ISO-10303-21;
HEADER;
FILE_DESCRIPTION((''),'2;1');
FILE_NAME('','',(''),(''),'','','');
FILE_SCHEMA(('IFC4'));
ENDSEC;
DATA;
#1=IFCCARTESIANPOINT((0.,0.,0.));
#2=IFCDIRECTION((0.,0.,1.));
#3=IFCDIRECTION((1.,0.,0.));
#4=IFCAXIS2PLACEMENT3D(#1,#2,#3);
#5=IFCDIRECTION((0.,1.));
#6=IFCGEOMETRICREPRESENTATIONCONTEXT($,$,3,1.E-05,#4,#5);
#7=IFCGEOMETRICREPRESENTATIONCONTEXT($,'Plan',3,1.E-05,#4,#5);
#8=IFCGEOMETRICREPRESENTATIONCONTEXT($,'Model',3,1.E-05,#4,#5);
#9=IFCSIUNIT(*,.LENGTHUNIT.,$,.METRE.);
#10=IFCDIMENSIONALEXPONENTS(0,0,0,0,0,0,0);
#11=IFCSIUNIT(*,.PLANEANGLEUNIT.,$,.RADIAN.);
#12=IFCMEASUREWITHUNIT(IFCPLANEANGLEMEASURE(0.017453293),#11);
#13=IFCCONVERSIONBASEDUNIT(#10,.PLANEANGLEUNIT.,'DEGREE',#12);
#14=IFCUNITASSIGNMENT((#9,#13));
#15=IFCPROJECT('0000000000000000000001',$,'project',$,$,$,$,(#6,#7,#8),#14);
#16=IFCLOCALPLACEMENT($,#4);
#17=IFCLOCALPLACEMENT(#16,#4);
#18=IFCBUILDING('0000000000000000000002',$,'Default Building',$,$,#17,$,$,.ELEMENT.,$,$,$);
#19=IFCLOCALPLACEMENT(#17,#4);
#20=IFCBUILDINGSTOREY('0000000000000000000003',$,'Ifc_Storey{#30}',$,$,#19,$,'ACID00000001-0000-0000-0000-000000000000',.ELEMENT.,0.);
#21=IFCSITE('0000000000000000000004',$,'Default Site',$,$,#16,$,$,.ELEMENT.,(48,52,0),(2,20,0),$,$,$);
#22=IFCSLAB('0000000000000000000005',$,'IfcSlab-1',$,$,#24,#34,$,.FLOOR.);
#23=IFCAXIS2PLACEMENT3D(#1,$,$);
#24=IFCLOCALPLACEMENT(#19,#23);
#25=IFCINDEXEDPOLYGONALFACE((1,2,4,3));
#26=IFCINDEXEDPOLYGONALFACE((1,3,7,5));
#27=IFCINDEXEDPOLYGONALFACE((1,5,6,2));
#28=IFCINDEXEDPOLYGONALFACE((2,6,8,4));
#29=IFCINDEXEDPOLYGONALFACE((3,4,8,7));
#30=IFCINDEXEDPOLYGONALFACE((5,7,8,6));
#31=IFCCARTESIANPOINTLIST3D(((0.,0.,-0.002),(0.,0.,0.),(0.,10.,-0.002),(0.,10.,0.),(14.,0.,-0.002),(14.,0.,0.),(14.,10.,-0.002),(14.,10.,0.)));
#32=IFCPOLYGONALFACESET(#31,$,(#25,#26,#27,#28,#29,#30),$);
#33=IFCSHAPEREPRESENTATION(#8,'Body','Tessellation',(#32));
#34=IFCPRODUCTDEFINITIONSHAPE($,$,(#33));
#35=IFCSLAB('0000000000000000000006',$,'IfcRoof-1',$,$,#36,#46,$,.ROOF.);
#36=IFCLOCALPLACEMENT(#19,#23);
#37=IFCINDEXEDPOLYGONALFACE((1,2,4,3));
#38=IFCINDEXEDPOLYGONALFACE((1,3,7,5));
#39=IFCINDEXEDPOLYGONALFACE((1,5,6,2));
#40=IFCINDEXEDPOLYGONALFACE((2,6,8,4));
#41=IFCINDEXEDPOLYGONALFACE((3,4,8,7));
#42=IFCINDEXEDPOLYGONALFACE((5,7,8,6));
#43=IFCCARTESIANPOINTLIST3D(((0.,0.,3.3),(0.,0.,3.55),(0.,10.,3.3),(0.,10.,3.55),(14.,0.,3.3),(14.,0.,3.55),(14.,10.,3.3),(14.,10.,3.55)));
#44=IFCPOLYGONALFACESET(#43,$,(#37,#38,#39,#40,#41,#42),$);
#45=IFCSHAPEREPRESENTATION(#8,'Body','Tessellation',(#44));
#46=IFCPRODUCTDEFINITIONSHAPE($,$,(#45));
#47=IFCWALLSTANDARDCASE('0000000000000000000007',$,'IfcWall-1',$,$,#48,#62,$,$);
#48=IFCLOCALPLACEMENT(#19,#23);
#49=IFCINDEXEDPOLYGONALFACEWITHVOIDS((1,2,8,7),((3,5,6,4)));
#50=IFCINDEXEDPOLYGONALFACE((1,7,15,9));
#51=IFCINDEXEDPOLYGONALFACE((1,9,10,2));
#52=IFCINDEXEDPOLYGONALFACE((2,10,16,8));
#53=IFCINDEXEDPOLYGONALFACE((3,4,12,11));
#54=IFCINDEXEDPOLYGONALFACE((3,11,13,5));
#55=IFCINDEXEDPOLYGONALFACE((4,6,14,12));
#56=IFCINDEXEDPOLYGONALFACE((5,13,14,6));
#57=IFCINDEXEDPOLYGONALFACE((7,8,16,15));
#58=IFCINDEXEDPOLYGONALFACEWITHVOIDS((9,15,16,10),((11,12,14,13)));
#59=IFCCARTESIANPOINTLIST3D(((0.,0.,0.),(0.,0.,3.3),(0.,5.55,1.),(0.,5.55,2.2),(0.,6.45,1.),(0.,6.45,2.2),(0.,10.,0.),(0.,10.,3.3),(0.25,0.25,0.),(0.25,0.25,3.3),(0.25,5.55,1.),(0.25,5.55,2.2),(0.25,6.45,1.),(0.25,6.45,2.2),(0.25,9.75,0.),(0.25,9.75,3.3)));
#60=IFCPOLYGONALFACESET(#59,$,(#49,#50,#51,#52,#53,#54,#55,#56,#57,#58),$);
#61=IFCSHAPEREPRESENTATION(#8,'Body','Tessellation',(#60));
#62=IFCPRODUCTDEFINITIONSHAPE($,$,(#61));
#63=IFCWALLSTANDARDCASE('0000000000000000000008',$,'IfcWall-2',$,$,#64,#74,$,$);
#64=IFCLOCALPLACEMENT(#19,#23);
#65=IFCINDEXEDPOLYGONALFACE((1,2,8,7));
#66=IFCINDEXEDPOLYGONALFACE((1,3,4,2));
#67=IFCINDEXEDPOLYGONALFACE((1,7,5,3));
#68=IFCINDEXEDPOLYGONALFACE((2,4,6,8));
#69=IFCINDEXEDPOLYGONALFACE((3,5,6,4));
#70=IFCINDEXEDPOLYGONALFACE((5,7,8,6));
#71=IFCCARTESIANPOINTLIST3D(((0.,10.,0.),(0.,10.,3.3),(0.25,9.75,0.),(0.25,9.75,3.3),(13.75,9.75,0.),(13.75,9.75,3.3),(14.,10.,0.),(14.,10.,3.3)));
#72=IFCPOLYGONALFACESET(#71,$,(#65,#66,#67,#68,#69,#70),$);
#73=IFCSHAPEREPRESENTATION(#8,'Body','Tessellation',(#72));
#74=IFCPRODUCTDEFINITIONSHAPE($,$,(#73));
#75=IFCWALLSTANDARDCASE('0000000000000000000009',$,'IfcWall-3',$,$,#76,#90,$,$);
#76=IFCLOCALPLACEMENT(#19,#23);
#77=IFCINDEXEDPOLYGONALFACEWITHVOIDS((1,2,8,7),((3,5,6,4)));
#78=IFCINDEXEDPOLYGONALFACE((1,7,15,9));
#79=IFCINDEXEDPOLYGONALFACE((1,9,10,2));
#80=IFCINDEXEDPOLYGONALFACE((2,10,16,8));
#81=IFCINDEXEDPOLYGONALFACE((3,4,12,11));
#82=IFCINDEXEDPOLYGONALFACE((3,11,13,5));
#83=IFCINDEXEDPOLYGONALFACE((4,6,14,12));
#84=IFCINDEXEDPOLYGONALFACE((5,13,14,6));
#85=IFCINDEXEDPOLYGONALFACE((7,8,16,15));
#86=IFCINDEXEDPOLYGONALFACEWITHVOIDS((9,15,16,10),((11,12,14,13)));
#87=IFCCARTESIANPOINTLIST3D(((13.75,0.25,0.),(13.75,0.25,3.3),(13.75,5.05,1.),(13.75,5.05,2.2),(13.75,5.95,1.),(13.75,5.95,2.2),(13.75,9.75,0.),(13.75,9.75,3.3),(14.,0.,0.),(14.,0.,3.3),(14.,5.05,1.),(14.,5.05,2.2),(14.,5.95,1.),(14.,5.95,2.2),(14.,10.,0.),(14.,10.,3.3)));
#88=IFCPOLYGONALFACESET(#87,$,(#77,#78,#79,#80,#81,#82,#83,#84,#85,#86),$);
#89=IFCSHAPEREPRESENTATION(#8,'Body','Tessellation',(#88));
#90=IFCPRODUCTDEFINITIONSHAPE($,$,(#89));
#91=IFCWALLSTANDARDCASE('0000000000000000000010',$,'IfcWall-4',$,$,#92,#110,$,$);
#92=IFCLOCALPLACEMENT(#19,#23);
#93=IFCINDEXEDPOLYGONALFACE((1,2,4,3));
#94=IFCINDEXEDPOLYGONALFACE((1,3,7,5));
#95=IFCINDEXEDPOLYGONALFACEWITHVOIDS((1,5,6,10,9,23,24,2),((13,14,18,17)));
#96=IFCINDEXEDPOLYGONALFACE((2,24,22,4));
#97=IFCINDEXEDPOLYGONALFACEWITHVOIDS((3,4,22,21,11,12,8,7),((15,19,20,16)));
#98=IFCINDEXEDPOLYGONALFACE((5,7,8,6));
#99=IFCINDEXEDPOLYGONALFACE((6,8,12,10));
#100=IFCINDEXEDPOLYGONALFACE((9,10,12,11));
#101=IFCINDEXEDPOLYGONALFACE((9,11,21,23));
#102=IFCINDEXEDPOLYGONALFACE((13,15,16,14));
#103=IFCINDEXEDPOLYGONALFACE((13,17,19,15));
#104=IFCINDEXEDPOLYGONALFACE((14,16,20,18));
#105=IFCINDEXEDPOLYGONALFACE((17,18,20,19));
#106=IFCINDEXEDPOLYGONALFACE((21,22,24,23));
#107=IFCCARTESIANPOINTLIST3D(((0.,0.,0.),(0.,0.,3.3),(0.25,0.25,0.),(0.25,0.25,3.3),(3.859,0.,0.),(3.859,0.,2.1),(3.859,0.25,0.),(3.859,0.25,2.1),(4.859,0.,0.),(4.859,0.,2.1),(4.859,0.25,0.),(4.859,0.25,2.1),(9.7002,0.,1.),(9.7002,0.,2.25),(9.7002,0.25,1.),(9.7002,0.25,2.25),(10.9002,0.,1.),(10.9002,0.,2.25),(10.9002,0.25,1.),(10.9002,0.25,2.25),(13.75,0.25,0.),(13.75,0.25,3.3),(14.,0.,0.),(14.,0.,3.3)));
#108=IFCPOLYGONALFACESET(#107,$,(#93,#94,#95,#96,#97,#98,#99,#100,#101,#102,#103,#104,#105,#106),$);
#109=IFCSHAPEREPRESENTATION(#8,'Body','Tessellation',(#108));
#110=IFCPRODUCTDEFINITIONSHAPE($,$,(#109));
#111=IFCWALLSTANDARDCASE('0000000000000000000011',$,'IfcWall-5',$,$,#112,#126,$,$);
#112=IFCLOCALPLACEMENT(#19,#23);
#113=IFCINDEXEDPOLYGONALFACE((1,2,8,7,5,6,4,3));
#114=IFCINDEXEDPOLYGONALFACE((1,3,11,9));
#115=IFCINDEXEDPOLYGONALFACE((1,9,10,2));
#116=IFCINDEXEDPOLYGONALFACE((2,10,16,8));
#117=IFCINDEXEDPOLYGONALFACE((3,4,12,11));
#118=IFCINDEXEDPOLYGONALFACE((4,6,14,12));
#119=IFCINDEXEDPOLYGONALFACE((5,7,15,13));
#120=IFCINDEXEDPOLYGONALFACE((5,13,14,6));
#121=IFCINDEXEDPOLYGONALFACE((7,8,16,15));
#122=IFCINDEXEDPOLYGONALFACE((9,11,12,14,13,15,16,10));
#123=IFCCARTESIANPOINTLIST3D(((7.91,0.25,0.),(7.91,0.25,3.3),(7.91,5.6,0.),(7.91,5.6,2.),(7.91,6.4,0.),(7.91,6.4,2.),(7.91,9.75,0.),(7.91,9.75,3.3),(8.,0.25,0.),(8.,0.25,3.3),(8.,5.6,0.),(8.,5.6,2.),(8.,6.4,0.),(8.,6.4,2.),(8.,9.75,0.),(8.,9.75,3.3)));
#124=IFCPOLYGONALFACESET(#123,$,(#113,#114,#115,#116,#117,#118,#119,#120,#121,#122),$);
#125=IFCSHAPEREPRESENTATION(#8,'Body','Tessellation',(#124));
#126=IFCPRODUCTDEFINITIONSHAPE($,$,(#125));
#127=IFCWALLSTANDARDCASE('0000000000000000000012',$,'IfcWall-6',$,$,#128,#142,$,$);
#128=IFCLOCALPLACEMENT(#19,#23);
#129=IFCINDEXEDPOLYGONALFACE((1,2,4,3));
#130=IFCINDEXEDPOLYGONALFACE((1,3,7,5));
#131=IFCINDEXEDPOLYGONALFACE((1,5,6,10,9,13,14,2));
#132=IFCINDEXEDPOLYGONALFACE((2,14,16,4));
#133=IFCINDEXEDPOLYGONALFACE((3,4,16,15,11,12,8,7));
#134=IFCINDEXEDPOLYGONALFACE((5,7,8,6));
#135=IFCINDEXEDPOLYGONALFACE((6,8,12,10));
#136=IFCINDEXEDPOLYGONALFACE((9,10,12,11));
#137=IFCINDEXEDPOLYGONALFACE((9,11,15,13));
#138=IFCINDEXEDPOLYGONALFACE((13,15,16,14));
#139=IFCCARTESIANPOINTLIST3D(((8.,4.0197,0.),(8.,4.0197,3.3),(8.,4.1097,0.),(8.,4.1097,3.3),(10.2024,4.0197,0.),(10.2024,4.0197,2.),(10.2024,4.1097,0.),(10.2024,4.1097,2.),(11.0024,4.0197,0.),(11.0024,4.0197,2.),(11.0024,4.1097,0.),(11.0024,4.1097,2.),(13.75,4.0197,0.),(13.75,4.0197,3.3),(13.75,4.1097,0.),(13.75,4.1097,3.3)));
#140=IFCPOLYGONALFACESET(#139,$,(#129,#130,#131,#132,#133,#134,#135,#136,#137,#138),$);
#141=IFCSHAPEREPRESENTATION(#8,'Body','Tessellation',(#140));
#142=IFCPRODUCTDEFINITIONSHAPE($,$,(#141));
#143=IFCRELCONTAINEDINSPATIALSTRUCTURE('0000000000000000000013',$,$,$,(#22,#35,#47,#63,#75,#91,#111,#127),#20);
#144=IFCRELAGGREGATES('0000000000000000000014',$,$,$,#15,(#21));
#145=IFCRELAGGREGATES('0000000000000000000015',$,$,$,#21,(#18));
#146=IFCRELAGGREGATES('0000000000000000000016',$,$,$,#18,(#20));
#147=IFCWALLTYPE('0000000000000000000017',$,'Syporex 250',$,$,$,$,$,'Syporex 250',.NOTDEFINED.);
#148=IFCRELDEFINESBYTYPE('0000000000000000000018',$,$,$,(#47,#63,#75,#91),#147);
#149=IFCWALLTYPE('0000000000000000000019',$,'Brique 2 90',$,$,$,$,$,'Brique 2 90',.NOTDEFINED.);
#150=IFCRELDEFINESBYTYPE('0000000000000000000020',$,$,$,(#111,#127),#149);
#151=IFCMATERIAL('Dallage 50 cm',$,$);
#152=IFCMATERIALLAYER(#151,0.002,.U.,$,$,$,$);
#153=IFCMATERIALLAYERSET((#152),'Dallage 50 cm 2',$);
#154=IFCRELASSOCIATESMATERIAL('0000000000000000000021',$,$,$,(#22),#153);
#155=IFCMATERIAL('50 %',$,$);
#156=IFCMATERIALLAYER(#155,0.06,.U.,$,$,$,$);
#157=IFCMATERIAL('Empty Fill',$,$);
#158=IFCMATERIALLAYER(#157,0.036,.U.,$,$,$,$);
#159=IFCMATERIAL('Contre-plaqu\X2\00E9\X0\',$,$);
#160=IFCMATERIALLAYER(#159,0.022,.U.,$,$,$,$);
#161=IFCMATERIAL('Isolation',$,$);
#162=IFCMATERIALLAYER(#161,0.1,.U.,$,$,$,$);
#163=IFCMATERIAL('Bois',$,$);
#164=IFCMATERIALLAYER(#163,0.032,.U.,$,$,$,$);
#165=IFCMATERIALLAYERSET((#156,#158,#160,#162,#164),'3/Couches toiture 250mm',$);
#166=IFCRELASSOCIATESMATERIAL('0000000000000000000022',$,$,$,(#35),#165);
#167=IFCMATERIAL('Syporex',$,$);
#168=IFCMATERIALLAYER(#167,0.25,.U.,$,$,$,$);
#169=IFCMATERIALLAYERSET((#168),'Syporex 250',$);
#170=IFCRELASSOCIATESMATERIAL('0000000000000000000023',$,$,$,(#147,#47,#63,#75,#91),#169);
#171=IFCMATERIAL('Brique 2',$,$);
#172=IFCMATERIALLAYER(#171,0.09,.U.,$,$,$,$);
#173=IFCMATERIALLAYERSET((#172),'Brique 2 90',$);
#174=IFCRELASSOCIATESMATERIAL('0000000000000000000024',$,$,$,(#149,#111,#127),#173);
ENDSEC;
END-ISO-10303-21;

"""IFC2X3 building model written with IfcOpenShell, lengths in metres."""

from ifc_helpers import new_model, entity, si_unit, converted_unit, direction, frame, frame_2d, origin_with_axes, place, context, project, spatial, polyline, rectangle, outline, extrude, material, layer, layer_set, layer_usage, type_object, element, save


model = new_model("IFC2X3")

# Units and contexts
context_of_model = context(None, 3, precision=1e-05, world=origin_with_axes(), true_north=direction((0.0, 1.0)))
plan_context = context("Plan", 3, precision=1e-05, world=origin_with_axes(), true_north=direction((0.0, 1.0)))
model_context = context("Model", 3, precision=1e-05, world=origin_with_axes(), true_north=direction((0.0, 1.0)))
ifc_project = project(units=[si_unit("LENGTHUNIT", "METRE"), converted_unit("PLANEANGLEUNIT", "DEGREE", entity("IfcPlaneAngleMeasure", 0.017453293), si_unit("PLANEANGLEUNIT", "RADIAN"), dimensions=[0, 0, 0, 0, 0, 0, 0])], contexts=[context_of_model, plan_context, model_context])

# Site, building, storey
site_placement = place(None, origin_with_axes())
site = spatial("IfcSite", under=ifc_project, at=site_placement, Name="Default Site", CompositionType="ELEMENT", RefLatitude=(48, 52, 0), RefLongitude=(2, 20, 0))
building_placement = place(site_placement, origin_with_axes())
building = spatial("IfcBuilding", under=site, at=building_placement, Name="Default Building", CompositionType="ELEMENT")
storey_placement = place(building_placement, origin_with_axes())
storey = spatial("IfcBuildingStorey", under=building, at=storey_placement, Name="Ifc_Storey{#30}", LongName="ACID00000001-0000-0000-0000-000000000000", CompositionType="ELEMENT", Elevation=0.0)

# Slabs
ifc_material_1 = material(Name="Dallage 50 cm")
ifc_layer_1 = layer(ifc_material_1, 0.002, ventilated="UNKNOWN")
ifc_layer_set_1 = layer_set([ifc_layer_1], Name="Dallage 50 cm 2")
ifc_layer_usage_1 = layer_usage(ifc_layer_set_1, "AXIS3", "NEGATIVE", 0.002)
slab_1_placement = place(storey_placement, frame((0.0, 10.0, -0.002), z_axis=(0.0, 0.0, 1.0), x_axis=(0.0, -1.0, 0.0)))
element("IfcSlab", 1, at=slab_1_placement, inside=storey, material=ifc_layer_usage_1, Name="IfcSlab-1", PredefinedType="FLOOR", context=model_context, shape_type="SweptSolid", body=[
    extrude(outline(polyline([(0.0, 0.0), (10.0, 0.0), (10.0, 14.0), (0.0, 14.0), (0.0, 0.0)])), origin_with_axes(), (0.0, 0.0, 1.0), 0.002),
])
ifc_material_2 = material(Name="50 %")
ifc_layer_2 = layer(ifc_material_2, 0.06, ventilated="UNKNOWN")
ifc_material_3 = material(Name="Empty Fill")
ifc_layer_3 = layer(ifc_material_3, 0.036, ventilated="UNKNOWN")
ifc_material_4 = material(Name="Contre-plaqué")
ifc_layer_4 = layer(ifc_material_4, 0.022, ventilated="UNKNOWN")
ifc_material_5 = material(Name="Isolation")
ifc_layer_5 = layer(ifc_material_5, 0.1, ventilated="UNKNOWN")
ifc_material_6 = material(Name="Bois")
ifc_layer_6 = layer(ifc_material_6, 0.032, ventilated="UNKNOWN")
ifc_layer_set_2 = layer_set([ifc_layer_2, ifc_layer_3, ifc_layer_4, ifc_layer_5, ifc_layer_6], Name="3/Couches toiture 250mm")
ifc_layer_usage_2 = layer_usage(ifc_layer_set_2, "AXIS3", "NEGATIVE", 0.25)
slab_2_placement = place(storey_placement, frame((0.0, 10.0, 3.3), z_axis=(0.0, 0.0, 1.0), x_axis=(1.0, 0.0, 0.0)))
element("IfcSlab", 2, at=slab_2_placement, inside=storey, material=ifc_layer_usage_2, Name="IfcRoof-1", PredefinedType="ROOF", context=model_context, shape_type="SweptSolid", body=[
    extrude(outline(polyline([(0.0, 0.0), (0.0, -10.0), (14.0, -10.0), (14.0, 0.0), (0.0, 0.0)])), origin_with_axes(), (0.0, 0.0, 1.0), 0.25),
])

# Wall, opening
ifc_material_7 = material(Name="Syporex")
ifc_layer_7 = layer(ifc_material_7, 0.25, ventilated="UNKNOWN")
ifc_layer_set_3 = layer_set([ifc_layer_7], Name="Syporex 250")
ifc_layer_usage_3 = layer_usage(ifc_layer_set_3, "AXIS2", "NEGATIVE", 0.0)
wall_type_1 = type_object("IfcWallType", Name="Syporex 250", ElementType="Syporex 250", PredefinedType="NOTDEFINED", material=ifc_layer_set_3)
wall_1_placement = place(storey_placement, frame((0.0, 0.0, 0.0), z_axis=(0.0, 0.0, 1.0), x_axis=(0.0, 1.0, 0.0)))
wall_1 = element("IfcWallStandardCase", 3, at=wall_1_placement, inside=storey, type_object=wall_type_1, material=ifc_layer_usage_3, Name="IfcWall-1", context=model_context, shape_type="SweptSolid", body=[
    extrude(outline(polyline([(0.25, -0.25), (9.75, -0.25), (10.0, 0.0), (0.0, 0.0), (0.25, -0.25)])), origin_with_axes(), (0.0, 0.0, 1.0), 3.3),
])
opening_1_placement = place(wall_1_placement, frame((6.0, -0.25, 1.0), z_axis=(0.0, 0.0, 1.0), x_axis=(1.0, 0.0, 0.0)))
element("IfcOpeningElement", 4, at=opening_1_placement, inside=storey, cuts=wall_1, ObjectType="Opening", context=model_context, shape_type="SweptSolid", body=[
    extrude(rectangle(XDim=0.9, YDim=1.2, at=frame_2d((0.0, 0.6), x_axis=(-1.0, 0.0))), frame((0.0, 0.0, 0.0), z_axis=(0.0, 1.0, 0.0), x_axis=(-1.0, 0.0, 0.0)), (0.0, 0.0, 1.0), 0.25),
])

# Wall
ifc_layer_usage_4 = layer_usage(ifc_layer_set_3, "AXIS2", "NEGATIVE", 0.0)
wall_2_placement = place(storey_placement, frame((0.0, 10.0, 0.0), z_axis=(0.0, 0.0, 1.0), x_axis=(1.0, 0.0, 0.0)))
element("IfcWallStandardCase", 5, at=wall_2_placement, inside=storey, type_object=wall_type_1, material=ifc_layer_usage_4, Name="IfcWall-2", context=model_context, shape_type="SweptSolid", body=[
    extrude(outline(polyline([(0.25, -0.25), (13.75, -0.25), (14.0, 0.0), (0.0, 0.0), (0.25, -0.25)])), origin_with_axes(), (0.0, 0.0, 1.0), 3.3),
])

# Wall, opening
ifc_layer_usage_5 = layer_usage(ifc_layer_set_3, "AXIS2", "NEGATIVE", 0.0)
wall_3_placement = place(storey_placement, frame((14.0, 10.0, 0.0), z_axis=(0.0, 0.0, 1.0), x_axis=(0.0, -1.0, 0.0)))
wall_3 = element("IfcWallStandardCase", 6, at=wall_3_placement, inside=storey, type_object=wall_type_1, material=ifc_layer_usage_5, Name="IfcWall-3", context=model_context, shape_type="SweptSolid", body=[
    extrude(outline(polyline([(0.25, -0.25), (9.75, -0.25), (10.0, 0.0), (0.0, 0.0), (0.25, -0.25)])), origin_with_axes(), (0.0, 0.0, 1.0), 3.3),
])
opening_2_placement = place(wall_3_placement, frame((4.5, -0.25, 1.0), z_axis=(0.0, 0.0, 1.0), x_axis=(1.0, 0.0, 0.0)))
element("IfcOpeningElement", 7, at=opening_2_placement, inside=storey, cuts=wall_3, ObjectType="Opening", context=model_context, shape_type="SweptSolid", body=[
    extrude(rectangle(XDim=0.9, YDim=1.2, at=frame_2d((0.0, 0.6), x_axis=(-1.0, 0.0))), frame((0.0, 0.0, 0.0), z_axis=(0.0, 1.0, 0.0), x_axis=(-1.0, 0.0, 0.0)), (0.0, 0.0, 1.0), 0.25),
])

# Wall, openings
ifc_layer_usage_6 = layer_usage(ifc_layer_set_3, "AXIS2", "NEGATIVE", 0.0)
wall_4_placement = place(storey_placement, frame((14.0, 0.0, 0.0), z_axis=(0.0, 0.0, 1.0), x_axis=(-1.0, 0.0, 0.0)))
wall_4 = element("IfcWallStandardCase", 8, at=wall_4_placement, inside=storey, type_object=wall_type_1, material=ifc_layer_usage_6, Name="IfcWall-4", context=model_context, shape_type="SweptSolid", body=[
    extrude(outline(polyline([(0.25, -0.25), (13.75, -0.25), (14.0, 0.0), (0.0, 0.0), (0.25, -0.25)])), origin_with_axes(), (0.0, 0.0, 1.0), 3.3),
])
opening_3_placement = place(wall_4_placement, frame((9.641, -0.25, 0.0), z_axis=(0.0, 0.0, 1.0), x_axis=(1.0, 0.0, 0.0)))
element("IfcOpeningElement", 9, at=opening_3_placement, cuts=wall_4, ObjectType="Opening", context=model_context, shape_type="SweptSolid", body=[
    extrude(rectangle(XDim=1.0, YDim=2.1, at=frame_2d((0.0, 1.05), x_axis=(1.0, 0.0))), frame((0.0, 0.0, 0.0), z_axis=(0.0, 1.0, 0.0), x_axis=(-1.0, 0.0, 0.0)), (0.0, 0.0, 1.0), 0.25),
])
opening_4_placement = place(wall_4_placement, frame((3.6998, -0.25, 1.0), z_axis=(0.0, 0.0, 1.0), x_axis=(1.0, 0.0, 0.0)))
element("IfcOpeningElement", 10, at=opening_4_placement, inside=storey, cuts=wall_4, ObjectType="Opening", context=model_context, shape_type="SweptSolid", body=[
    extrude(rectangle(XDim=1.2, YDim=1.25, at=frame_2d((0.0, 0.625), x_axis=(-1.0, 0.0))), frame((0.0, 0.0, 0.0), z_axis=(0.0, 1.0, 0.0), x_axis=(-1.0, 0.0, 0.0)), (0.0, 0.0, 1.0), 0.25),
])

# Walls, openings
ifc_material_8 = material(Name="Brique 2")
ifc_layer_8 = layer(ifc_material_8, 0.09, ventilated="UNKNOWN")
ifc_layer_set_4 = layer_set([ifc_layer_8], Name="Brique 2 90")
ifc_layer_usage_7 = layer_usage(ifc_layer_set_4, "AXIS2", "NEGATIVE", 0.0)
wall_type_2 = type_object("IfcWallType", Name="Brique 2 90", ElementType="Brique 2 90", PredefinedType="NOTDEFINED", material=ifc_layer_set_4)
wall_5_placement = place(storey_placement, frame((8.0, 10.0, 0.0), z_axis=(0.0, 0.0, 1.0), x_axis=(0.0, -1.0, 0.0)))
wall_5 = element("IfcWallStandardCase", 11, at=wall_5_placement, inside=storey, type_object=wall_type_2, material=ifc_layer_usage_7, Name="IfcWall-5", context=model_context, shape_type="SweptSolid", body=[
    extrude(outline(polyline([(0.25, -0.09), (9.75, -0.09), (9.75, 0.0), (0.25, 0.0), (0.25, -0.09)])), origin_with_axes(), (0.0, 0.0, 1.0), 3.3),
])
opening_5_placement = place(wall_5_placement, frame((4.0, -0.09, 0.0), z_axis=(0.0, 0.0, 1.0), x_axis=(1.0, 0.0, 0.0)))
element("IfcOpeningElement", 12, at=opening_5_placement, inside=storey, cuts=wall_5, ObjectType="Opening", context=model_context, shape_type="SweptSolid", body=[
    extrude(rectangle(XDim=0.8, YDim=2.0, at=frame_2d((0.0, 1.0), x_axis=(-1.0, 0.0))), frame((0.0, 0.0, 0.0), z_axis=(0.0, 1.0, 0.0), x_axis=(-1.0, 0.0, 0.0)), (0.0, 0.0, 1.0), 0.09),
])
ifc_layer_usage_8 = layer_usage(ifc_layer_set_4, "AXIS2", "NEGATIVE", 0.0)
wall_6_placement = place(storey_placement, frame((8.0, 4.1097, 0.0), z_axis=(0.0, 0.0, 1.0), x_axis=(1.0, 0.0, 0.0)))
wall_6 = element("IfcWallStandardCase", 13, at=wall_6_placement, inside=storey, type_object=wall_type_2, material=ifc_layer_usage_8, Name="IfcWall-6", context=model_context, shape_type="SweptSolid", body=[
    extrude(outline(polyline([(0.0, -0.09), (5.75, -0.09), (5.75, 0.0), (0.0, 0.0), (0.0, -0.09)])), origin_with_axes(), (0.0, 0.0, 1.0), 3.3),
])
opening_6_placement = place(wall_6_placement, frame((2.6024, -0.3, 0.0), z_axis=(0.0, 0.0, 1.0), x_axis=(1.0, 0.0, 0.0)))
element("IfcOpeningElement", 14, at=opening_6_placement, inside=storey, cuts=wall_6, ObjectType="Opening", context=model_context, shape_type="SweptSolid", body=[
    extrude(rectangle(XDim=0.8, YDim=2.0, at=frame_2d((0.0, 1.0), x_axis=(-1.0, 0.0))), frame((0.0, 0.0, 0.0), z_axis=(0.0, 1.0, 0.0), x_axis=(-1.0, 0.0, 0.0)), (0.0, 0.0, 1.0), 0.3),
])

save(model, "model.ifc")
